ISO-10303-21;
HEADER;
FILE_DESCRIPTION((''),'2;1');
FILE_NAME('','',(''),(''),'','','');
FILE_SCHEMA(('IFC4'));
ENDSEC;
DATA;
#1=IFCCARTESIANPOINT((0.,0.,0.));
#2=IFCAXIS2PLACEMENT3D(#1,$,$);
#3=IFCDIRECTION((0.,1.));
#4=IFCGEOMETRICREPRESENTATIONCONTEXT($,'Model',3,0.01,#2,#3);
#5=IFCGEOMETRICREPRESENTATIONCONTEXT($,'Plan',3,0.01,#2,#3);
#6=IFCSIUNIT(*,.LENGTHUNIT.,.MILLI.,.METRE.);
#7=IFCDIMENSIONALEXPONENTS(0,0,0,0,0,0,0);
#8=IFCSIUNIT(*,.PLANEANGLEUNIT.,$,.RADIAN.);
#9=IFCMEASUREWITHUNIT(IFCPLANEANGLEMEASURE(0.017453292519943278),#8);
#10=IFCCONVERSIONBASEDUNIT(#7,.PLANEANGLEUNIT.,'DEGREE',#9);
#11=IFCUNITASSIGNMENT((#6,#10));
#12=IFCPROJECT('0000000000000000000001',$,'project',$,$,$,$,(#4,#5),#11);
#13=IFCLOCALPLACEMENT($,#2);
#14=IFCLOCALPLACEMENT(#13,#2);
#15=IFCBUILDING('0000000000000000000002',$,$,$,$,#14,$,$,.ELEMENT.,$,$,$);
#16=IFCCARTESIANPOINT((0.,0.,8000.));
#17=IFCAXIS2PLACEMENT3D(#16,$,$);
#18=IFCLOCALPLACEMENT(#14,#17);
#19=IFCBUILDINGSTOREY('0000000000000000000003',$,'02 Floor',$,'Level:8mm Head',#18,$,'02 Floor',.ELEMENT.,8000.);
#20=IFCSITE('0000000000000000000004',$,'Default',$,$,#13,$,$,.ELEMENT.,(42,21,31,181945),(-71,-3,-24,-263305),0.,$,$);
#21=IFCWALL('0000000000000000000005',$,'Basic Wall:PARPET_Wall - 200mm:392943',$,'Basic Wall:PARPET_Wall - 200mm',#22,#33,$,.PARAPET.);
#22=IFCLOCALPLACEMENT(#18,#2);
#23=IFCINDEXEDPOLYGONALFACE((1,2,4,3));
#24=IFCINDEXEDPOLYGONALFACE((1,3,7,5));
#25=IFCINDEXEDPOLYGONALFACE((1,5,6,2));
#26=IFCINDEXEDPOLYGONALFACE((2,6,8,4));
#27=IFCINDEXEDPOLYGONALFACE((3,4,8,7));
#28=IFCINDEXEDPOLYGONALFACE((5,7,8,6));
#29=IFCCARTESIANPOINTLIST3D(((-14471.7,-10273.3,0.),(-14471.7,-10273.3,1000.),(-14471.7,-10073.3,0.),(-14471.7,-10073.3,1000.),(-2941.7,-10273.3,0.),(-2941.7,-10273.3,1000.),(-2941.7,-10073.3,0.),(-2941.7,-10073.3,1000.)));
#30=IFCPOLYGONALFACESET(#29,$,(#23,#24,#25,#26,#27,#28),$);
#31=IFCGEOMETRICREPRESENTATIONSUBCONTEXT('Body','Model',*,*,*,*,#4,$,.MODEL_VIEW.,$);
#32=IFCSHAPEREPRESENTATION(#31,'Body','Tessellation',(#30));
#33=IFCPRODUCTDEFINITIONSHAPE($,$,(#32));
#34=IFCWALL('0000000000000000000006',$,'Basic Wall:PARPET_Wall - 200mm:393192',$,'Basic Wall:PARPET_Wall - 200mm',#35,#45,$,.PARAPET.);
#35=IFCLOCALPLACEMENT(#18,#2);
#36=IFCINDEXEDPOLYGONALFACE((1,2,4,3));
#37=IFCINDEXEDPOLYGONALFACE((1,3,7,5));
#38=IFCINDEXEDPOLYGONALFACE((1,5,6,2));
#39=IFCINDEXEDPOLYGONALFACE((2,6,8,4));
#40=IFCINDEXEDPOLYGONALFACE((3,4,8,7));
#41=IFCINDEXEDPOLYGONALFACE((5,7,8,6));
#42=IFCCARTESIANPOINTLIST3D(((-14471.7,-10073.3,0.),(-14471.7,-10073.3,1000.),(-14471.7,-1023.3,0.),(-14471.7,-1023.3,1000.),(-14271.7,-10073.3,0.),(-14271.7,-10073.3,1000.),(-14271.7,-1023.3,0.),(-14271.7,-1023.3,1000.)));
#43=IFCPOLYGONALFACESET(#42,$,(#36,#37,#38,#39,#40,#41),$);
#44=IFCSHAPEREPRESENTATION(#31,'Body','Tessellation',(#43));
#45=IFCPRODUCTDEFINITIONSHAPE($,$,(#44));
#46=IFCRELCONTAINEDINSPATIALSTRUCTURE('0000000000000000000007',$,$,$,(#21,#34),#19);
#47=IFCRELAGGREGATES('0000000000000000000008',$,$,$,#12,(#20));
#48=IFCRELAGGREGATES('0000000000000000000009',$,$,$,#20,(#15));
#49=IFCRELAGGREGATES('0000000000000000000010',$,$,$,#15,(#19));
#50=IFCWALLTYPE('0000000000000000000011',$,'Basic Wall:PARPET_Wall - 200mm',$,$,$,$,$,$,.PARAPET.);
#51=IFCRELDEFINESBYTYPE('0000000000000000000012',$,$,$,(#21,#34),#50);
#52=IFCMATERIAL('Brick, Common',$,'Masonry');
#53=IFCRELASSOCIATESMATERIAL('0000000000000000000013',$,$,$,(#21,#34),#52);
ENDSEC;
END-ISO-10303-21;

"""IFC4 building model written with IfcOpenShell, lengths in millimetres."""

from ifc_helpers import new_model, entity, si_unit, converted_unit, direction, frame, origin, place, context, subcontext, project, spatial, indexed_curve, outline, extrude, material, type_object, element, save


model = new_model("IFC4")

# Units and contexts
model_context = context("Model", 3, precision=0.01, world=origin(), true_north=direction((0.0, 1.0)))
plan_context = context("Plan", 3, precision=0.01, world=origin(), true_north=direction((0.0, 1.0)))
body_context = subcontext(model_context, "Body", "Model", "MODEL_VIEW")
ifc_project = project(units=[si_unit("LENGTHUNIT", "METRE", prefix="MILLI"), converted_unit("PLANEANGLEUNIT", "DEGREE", entity("IfcPlaneAngleMeasure", 0.017453292519943278), si_unit("PLANEANGLEUNIT", "RADIAN"), dimensions=[0, 0, 0, 0, 0, 0, 0])], contexts=[model_context, plan_context])

# Site, building, storey
site_placement = place(None, origin())
site = spatial("IfcSite", under=ifc_project, at=site_placement, Name="Default", CompositionType="ELEMENT", RefLatitude=(42, 21, 31, 181945), RefLongitude=(-71, -3, -24, -263305), RefElevation=0.0)
building_placement = place(site_placement, origin())
building = spatial("IfcBuilding", under=site, at=building_placement, CompositionType="ELEMENT")
storey_placement = place(building_placement, frame((0.0, 0.0, 8000.0)))
storey = spatial("IfcBuildingStorey", under=building, at=storey_placement, Name="02 Floor", ObjectType="Level:8mm Head", LongName="02 Floor", CompositionType="ELEMENT", Elevation=8000.0)

# Walls
ifc_material_1 = material(Name="Brick, Common", Category="Masonry")
wall_type = type_object("IfcWallType", Name="Basic Wall:PARPET_Wall - 200mm", PredefinedType="PARAPET")
wall_1_placement = place(storey_placement, frame((-2941.7, -10173.3, 0.0), z_axis=(0.0, 0.0, 1.0), x_axis=(-1.0, 0.0, 0.0)))
element("IfcWall", 1, at=wall_1_placement, inside=storey, type_object=wall_type, material=ifc_material_1, Name="Basic Wall:PARPET_Wall - 200mm:392943", ObjectType="Basic Wall:PARPET_Wall - 200mm", PredefinedType="PARAPET", context=body_context, shape_type="SweptSolid", body=[
    extrude(outline(indexed_curve([(11530.0, 100.0), (0.0, 100.0), (0.0, -100.0), (11530.0, -100.0), (11530.0, 100.0)], self_intersect=False)), origin(), (0.0, 0.0, 1.0), 1000.0),
])
wall_2_placement = place(storey_placement, frame((-14371.7, -10073.3, 0.0), z_axis=(0.0, 0.0, 1.0), x_axis=(0.0, 1.0, 0.0)))
element("IfcWall", 2, at=wall_2_placement, inside=storey, type_object=wall_type, material=ifc_material_1, Name="Basic Wall:PARPET_Wall - 200mm:393192", ObjectType="Basic Wall:PARPET_Wall - 200mm", PredefinedType="PARAPET", context=body_context, shape_type="SweptSolid", body=[
    extrude(outline(indexed_curve([(9050.0, 100.0), (0.0, 100.0), (0.0, -100.0), (9050.0, -100.0), (9050.0, 100.0)], self_intersect=False)), origin(), (0.0, 0.0, 1.0), 1000.0),
])

save(model, "model.ifc")
